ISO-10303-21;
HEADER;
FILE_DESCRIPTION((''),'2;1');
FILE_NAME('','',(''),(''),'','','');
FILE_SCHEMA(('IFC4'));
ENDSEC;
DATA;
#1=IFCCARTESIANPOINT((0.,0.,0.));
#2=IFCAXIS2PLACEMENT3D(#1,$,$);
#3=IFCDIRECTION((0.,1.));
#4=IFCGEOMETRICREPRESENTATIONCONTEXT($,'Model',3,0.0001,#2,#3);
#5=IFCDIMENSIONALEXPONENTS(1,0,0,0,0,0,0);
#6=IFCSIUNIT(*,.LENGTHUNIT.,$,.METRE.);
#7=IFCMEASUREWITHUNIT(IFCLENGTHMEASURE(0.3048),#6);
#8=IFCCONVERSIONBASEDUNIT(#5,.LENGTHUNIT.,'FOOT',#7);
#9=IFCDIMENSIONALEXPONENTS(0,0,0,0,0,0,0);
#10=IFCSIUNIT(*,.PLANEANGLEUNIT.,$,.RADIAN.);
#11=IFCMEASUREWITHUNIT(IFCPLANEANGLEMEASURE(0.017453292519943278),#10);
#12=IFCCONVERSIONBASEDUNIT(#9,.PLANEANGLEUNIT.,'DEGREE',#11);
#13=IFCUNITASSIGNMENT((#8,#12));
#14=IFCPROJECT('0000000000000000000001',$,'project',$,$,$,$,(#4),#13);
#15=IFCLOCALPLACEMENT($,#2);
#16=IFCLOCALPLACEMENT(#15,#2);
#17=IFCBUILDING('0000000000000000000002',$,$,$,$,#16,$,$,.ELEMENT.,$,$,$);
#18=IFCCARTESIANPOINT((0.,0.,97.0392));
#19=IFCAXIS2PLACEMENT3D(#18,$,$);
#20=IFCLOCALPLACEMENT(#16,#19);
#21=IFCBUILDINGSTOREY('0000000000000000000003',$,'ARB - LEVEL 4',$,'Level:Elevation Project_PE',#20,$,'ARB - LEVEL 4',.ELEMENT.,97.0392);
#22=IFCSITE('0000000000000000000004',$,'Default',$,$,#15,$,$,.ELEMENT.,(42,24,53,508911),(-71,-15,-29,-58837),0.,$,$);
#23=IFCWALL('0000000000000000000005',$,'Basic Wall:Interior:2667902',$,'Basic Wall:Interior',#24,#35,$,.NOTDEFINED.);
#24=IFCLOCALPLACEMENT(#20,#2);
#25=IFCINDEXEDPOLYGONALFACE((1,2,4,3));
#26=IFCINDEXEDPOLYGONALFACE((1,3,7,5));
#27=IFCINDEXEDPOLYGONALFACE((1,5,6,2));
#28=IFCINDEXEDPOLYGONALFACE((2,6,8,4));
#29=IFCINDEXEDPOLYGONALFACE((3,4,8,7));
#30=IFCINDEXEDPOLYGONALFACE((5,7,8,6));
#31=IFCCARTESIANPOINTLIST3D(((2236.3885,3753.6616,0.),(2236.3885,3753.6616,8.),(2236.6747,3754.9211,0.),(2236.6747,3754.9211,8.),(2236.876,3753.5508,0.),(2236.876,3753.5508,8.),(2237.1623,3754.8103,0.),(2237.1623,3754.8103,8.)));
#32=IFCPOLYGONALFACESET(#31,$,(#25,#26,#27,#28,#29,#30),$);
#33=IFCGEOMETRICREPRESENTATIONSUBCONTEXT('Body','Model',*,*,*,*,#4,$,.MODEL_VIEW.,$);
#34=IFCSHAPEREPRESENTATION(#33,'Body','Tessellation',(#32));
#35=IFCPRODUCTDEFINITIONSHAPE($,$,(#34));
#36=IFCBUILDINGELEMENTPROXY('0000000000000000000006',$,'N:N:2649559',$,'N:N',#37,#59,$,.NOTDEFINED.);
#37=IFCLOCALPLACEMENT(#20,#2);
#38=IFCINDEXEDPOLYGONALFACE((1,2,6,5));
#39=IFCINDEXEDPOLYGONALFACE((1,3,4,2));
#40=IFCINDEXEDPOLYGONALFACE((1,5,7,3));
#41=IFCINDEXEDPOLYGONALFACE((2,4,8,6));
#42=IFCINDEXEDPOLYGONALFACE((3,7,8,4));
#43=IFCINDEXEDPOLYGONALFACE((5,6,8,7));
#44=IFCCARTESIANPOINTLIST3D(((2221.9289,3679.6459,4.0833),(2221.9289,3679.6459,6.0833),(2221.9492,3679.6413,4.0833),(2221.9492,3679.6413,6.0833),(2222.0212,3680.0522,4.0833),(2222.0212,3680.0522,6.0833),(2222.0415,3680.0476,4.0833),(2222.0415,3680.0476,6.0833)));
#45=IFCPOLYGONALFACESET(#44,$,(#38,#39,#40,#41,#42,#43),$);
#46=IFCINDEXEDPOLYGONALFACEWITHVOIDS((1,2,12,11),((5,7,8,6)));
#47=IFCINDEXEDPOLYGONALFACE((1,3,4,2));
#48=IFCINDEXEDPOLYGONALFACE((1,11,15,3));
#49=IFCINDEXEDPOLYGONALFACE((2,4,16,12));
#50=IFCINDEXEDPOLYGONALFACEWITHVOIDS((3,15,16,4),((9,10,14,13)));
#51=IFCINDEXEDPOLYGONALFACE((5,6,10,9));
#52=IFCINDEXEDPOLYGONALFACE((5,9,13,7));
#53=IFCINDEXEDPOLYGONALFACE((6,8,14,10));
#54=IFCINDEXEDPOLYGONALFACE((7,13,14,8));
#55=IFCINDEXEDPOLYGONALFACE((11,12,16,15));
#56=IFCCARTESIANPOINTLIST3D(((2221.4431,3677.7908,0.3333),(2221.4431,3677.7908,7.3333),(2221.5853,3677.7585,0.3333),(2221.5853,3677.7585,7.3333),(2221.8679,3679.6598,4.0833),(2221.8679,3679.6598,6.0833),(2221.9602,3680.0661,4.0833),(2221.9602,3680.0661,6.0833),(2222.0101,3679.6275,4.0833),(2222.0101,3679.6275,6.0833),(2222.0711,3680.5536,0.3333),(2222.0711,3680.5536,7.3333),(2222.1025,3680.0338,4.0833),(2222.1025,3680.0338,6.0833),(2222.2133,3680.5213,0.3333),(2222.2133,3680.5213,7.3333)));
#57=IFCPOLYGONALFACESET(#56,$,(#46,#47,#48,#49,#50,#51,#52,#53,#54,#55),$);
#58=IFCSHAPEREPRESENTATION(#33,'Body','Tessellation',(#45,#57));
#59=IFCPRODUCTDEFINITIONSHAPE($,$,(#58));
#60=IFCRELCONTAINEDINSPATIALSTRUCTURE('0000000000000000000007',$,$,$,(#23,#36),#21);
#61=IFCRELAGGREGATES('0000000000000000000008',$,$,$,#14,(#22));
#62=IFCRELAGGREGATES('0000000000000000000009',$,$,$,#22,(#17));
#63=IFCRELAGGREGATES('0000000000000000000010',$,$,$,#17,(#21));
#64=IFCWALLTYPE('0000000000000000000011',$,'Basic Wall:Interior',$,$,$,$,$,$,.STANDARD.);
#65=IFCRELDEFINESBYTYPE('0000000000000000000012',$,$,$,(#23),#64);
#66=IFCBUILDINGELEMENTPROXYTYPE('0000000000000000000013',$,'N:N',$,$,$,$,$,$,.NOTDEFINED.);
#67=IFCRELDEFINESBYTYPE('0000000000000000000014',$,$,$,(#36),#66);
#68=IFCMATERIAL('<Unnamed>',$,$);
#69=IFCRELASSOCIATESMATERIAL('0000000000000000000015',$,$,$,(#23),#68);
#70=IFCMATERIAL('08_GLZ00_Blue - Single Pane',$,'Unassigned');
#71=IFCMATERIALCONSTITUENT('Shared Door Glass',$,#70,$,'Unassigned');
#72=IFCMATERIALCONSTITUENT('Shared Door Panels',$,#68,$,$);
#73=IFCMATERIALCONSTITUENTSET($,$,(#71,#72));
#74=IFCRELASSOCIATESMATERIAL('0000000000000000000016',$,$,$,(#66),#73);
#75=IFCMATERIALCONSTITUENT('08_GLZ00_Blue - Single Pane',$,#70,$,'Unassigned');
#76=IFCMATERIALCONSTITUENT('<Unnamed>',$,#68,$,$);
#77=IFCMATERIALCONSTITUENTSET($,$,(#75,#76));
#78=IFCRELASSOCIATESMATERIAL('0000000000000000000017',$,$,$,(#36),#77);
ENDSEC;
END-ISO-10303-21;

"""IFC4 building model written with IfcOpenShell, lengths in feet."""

from ifc_helpers import new_model, entity, si_unit, converted_unit, direction, frame, origin, place, context, subcontext, project, spatial, indexed_curve, outline, extrude, source, transform, mapped, material, constituent, constituent_set, type_object, type_shapes, element, save


model = new_model("IFC4")

# Units and contexts
model_context = context("Model", 3, precision=0.0001, world=origin(), true_north=direction((0.0, 1.0)))
body_context = subcontext(model_context, "Body", "Model", "MODEL_VIEW")
ifc_project = project(units=[converted_unit("LENGTHUNIT", "FOOT", entity("IfcLengthMeasure", 0.3048), si_unit("LENGTHUNIT", "METRE"), dimensions=[1, 0, 0, 0, 0, 0, 0]), converted_unit("PLANEANGLEUNIT", "DEGREE", entity("IfcPlaneAngleMeasure", 0.017453292519943278), si_unit("PLANEANGLEUNIT", "RADIAN"), dimensions=[0, 0, 0, 0, 0, 0, 0])], contexts=[model_context])

# Site, building, storey
site_placement = place(None, origin())
site = spatial("IfcSite", under=ifc_project, at=site_placement, Name="Default", CompositionType="ELEMENT", RefLatitude=(42, 24, 53, 508911), RefLongitude=(-71, -15, -29, -58837), RefElevation=0.0)
building_placement = place(site_placement, origin())
building = spatial("IfcBuilding", under=site, at=building_placement, CompositionType="ELEMENT")
storey_placement = place(building_placement, frame((0.0, 0.0, 97.0392)))
storey = spatial("IfcBuildingStorey", under=building, at=storey_placement, Name="ARB - LEVEL 4", ObjectType="Level:Elevation Project_PE", LongName="ARB - LEVEL 4", CompositionType="ELEMENT", Elevation=97.0392)

# Wall
ifc_material_1 = material(Name="<Unnamed>")
wall_type = type_object("IfcWallType", Name="Basic Wall:Interior", PredefinedType="STANDARD")
wall_1_placement = place(storey_placement, frame((2236.9185, 3754.8657, 0.0), z_axis=(0.0, 0.0, 1.0), x_axis=(-0.221622, -0.975133, 0.0)))
element("IfcWall", 1, at=wall_1_placement, inside=storey, type_object=wall_type, material=ifc_material_1, Name="Basic Wall:Interior:2667902", ObjectType="Basic Wall:Interior", PredefinedType="NOTDEFINED", context=body_context, shape_type="SweptSolid", body=[
    extrude(outline(indexed_curve([(1.2917, 0.25), (0.0, 0.25), (0.0, -0.25), (1.2917, -0.25), (1.2917, 0.25)], self_intersect=False)), origin(), (0.0, 0.0, 1.0), 8.0),
])

# Building element proxy
ifc_material_2 = material(Name="08_GLZ00_Blue - Single Pane", Category="Unassigned")
ifc_constituent_1 = constituent(ifc_material_2, Name="08_GLZ00_Blue - Single Pane", Category="Unassigned")
ifc_constituent_2 = constituent(ifc_material_1, Name="<Unnamed>")
ifc_constituent_set_1 = constituent_set(constituents=[ifc_constituent_1, ifc_constituent_2])
ifc_constituent_3 = constituent(ifc_material_2, Name="Shared Door Glass", Category="Unassigned")
ifc_constituent_4 = constituent(ifc_material_1, Name="Shared Door Panels")
ifc_constituent_set_2 = constituent_set(constituents=[ifc_constituent_3, ifc_constituent_4])
building_element_proxy_type = type_object("IfcBuildingElementProxyType", Name="N:N", PredefinedType="NOTDEFINED", material=ifc_constituent_set_2)
shared_shape = source(origin(), body_context, "Body", "SweptSolid", [
    extrude(outline(indexed_curve([(-0.0104, -0.2083), (0.0104, -0.2083), (0.0104, 0.2083), (-0.0104, 0.2083), (-0.0104, -0.2083)], self_intersect=False)), frame((-0.9942, 3.25, 3.75), z_axis=(0.0, 0.0, 1.0), x_axis=(0.0, 1.0, 0.0)), (0.0, 0.0, 1.0), 2.0),
    extrude(outline(indexed_curve([(-3.5, -1.4167), (3.5, -1.4167), (3.5, 1.4167), (-3.5, 1.4167), (-3.5, -1.4167)], self_intersect=False), holes=[indexed_curve([(-2.25, 0.5), (-2.25, 0.9167), (-0.25, 0.9167), (-0.25, 0.5), (-2.25, 0.5)], self_intersect=False)]), frame((-0.2859, 3.1771, 3.5), z_axis=(0.0, 1.0, 0.0), x_axis=(0.0, 0.0, -1.0)), (0.0, 0.0, 1.0), 0.1458),
])
type_shapes(building_element_proxy_type, [shared_shape])
proxy_placement = place(storey_placement, frame((2218.5957, 3679.5975, 0.3333), z_axis=(0.0, 0.0, 1.0), x_axis=(-0.221622, -0.975133, 0.0)))
element("IfcBuildingElementProxy", 2, at=proxy_placement, inside=storey, type_object=building_element_proxy_type, material=ifc_constituent_set_1, Name="N:N:2649559", ObjectType="N:N", PredefinedType="NOTDEFINED", context=body_context, shape_type="MappedRepresentation", body=[
    mapped(shared_shape, transform((0.0, 0.0, 0.0), scale=1.0)),
])

save(model, "model.ifc")
